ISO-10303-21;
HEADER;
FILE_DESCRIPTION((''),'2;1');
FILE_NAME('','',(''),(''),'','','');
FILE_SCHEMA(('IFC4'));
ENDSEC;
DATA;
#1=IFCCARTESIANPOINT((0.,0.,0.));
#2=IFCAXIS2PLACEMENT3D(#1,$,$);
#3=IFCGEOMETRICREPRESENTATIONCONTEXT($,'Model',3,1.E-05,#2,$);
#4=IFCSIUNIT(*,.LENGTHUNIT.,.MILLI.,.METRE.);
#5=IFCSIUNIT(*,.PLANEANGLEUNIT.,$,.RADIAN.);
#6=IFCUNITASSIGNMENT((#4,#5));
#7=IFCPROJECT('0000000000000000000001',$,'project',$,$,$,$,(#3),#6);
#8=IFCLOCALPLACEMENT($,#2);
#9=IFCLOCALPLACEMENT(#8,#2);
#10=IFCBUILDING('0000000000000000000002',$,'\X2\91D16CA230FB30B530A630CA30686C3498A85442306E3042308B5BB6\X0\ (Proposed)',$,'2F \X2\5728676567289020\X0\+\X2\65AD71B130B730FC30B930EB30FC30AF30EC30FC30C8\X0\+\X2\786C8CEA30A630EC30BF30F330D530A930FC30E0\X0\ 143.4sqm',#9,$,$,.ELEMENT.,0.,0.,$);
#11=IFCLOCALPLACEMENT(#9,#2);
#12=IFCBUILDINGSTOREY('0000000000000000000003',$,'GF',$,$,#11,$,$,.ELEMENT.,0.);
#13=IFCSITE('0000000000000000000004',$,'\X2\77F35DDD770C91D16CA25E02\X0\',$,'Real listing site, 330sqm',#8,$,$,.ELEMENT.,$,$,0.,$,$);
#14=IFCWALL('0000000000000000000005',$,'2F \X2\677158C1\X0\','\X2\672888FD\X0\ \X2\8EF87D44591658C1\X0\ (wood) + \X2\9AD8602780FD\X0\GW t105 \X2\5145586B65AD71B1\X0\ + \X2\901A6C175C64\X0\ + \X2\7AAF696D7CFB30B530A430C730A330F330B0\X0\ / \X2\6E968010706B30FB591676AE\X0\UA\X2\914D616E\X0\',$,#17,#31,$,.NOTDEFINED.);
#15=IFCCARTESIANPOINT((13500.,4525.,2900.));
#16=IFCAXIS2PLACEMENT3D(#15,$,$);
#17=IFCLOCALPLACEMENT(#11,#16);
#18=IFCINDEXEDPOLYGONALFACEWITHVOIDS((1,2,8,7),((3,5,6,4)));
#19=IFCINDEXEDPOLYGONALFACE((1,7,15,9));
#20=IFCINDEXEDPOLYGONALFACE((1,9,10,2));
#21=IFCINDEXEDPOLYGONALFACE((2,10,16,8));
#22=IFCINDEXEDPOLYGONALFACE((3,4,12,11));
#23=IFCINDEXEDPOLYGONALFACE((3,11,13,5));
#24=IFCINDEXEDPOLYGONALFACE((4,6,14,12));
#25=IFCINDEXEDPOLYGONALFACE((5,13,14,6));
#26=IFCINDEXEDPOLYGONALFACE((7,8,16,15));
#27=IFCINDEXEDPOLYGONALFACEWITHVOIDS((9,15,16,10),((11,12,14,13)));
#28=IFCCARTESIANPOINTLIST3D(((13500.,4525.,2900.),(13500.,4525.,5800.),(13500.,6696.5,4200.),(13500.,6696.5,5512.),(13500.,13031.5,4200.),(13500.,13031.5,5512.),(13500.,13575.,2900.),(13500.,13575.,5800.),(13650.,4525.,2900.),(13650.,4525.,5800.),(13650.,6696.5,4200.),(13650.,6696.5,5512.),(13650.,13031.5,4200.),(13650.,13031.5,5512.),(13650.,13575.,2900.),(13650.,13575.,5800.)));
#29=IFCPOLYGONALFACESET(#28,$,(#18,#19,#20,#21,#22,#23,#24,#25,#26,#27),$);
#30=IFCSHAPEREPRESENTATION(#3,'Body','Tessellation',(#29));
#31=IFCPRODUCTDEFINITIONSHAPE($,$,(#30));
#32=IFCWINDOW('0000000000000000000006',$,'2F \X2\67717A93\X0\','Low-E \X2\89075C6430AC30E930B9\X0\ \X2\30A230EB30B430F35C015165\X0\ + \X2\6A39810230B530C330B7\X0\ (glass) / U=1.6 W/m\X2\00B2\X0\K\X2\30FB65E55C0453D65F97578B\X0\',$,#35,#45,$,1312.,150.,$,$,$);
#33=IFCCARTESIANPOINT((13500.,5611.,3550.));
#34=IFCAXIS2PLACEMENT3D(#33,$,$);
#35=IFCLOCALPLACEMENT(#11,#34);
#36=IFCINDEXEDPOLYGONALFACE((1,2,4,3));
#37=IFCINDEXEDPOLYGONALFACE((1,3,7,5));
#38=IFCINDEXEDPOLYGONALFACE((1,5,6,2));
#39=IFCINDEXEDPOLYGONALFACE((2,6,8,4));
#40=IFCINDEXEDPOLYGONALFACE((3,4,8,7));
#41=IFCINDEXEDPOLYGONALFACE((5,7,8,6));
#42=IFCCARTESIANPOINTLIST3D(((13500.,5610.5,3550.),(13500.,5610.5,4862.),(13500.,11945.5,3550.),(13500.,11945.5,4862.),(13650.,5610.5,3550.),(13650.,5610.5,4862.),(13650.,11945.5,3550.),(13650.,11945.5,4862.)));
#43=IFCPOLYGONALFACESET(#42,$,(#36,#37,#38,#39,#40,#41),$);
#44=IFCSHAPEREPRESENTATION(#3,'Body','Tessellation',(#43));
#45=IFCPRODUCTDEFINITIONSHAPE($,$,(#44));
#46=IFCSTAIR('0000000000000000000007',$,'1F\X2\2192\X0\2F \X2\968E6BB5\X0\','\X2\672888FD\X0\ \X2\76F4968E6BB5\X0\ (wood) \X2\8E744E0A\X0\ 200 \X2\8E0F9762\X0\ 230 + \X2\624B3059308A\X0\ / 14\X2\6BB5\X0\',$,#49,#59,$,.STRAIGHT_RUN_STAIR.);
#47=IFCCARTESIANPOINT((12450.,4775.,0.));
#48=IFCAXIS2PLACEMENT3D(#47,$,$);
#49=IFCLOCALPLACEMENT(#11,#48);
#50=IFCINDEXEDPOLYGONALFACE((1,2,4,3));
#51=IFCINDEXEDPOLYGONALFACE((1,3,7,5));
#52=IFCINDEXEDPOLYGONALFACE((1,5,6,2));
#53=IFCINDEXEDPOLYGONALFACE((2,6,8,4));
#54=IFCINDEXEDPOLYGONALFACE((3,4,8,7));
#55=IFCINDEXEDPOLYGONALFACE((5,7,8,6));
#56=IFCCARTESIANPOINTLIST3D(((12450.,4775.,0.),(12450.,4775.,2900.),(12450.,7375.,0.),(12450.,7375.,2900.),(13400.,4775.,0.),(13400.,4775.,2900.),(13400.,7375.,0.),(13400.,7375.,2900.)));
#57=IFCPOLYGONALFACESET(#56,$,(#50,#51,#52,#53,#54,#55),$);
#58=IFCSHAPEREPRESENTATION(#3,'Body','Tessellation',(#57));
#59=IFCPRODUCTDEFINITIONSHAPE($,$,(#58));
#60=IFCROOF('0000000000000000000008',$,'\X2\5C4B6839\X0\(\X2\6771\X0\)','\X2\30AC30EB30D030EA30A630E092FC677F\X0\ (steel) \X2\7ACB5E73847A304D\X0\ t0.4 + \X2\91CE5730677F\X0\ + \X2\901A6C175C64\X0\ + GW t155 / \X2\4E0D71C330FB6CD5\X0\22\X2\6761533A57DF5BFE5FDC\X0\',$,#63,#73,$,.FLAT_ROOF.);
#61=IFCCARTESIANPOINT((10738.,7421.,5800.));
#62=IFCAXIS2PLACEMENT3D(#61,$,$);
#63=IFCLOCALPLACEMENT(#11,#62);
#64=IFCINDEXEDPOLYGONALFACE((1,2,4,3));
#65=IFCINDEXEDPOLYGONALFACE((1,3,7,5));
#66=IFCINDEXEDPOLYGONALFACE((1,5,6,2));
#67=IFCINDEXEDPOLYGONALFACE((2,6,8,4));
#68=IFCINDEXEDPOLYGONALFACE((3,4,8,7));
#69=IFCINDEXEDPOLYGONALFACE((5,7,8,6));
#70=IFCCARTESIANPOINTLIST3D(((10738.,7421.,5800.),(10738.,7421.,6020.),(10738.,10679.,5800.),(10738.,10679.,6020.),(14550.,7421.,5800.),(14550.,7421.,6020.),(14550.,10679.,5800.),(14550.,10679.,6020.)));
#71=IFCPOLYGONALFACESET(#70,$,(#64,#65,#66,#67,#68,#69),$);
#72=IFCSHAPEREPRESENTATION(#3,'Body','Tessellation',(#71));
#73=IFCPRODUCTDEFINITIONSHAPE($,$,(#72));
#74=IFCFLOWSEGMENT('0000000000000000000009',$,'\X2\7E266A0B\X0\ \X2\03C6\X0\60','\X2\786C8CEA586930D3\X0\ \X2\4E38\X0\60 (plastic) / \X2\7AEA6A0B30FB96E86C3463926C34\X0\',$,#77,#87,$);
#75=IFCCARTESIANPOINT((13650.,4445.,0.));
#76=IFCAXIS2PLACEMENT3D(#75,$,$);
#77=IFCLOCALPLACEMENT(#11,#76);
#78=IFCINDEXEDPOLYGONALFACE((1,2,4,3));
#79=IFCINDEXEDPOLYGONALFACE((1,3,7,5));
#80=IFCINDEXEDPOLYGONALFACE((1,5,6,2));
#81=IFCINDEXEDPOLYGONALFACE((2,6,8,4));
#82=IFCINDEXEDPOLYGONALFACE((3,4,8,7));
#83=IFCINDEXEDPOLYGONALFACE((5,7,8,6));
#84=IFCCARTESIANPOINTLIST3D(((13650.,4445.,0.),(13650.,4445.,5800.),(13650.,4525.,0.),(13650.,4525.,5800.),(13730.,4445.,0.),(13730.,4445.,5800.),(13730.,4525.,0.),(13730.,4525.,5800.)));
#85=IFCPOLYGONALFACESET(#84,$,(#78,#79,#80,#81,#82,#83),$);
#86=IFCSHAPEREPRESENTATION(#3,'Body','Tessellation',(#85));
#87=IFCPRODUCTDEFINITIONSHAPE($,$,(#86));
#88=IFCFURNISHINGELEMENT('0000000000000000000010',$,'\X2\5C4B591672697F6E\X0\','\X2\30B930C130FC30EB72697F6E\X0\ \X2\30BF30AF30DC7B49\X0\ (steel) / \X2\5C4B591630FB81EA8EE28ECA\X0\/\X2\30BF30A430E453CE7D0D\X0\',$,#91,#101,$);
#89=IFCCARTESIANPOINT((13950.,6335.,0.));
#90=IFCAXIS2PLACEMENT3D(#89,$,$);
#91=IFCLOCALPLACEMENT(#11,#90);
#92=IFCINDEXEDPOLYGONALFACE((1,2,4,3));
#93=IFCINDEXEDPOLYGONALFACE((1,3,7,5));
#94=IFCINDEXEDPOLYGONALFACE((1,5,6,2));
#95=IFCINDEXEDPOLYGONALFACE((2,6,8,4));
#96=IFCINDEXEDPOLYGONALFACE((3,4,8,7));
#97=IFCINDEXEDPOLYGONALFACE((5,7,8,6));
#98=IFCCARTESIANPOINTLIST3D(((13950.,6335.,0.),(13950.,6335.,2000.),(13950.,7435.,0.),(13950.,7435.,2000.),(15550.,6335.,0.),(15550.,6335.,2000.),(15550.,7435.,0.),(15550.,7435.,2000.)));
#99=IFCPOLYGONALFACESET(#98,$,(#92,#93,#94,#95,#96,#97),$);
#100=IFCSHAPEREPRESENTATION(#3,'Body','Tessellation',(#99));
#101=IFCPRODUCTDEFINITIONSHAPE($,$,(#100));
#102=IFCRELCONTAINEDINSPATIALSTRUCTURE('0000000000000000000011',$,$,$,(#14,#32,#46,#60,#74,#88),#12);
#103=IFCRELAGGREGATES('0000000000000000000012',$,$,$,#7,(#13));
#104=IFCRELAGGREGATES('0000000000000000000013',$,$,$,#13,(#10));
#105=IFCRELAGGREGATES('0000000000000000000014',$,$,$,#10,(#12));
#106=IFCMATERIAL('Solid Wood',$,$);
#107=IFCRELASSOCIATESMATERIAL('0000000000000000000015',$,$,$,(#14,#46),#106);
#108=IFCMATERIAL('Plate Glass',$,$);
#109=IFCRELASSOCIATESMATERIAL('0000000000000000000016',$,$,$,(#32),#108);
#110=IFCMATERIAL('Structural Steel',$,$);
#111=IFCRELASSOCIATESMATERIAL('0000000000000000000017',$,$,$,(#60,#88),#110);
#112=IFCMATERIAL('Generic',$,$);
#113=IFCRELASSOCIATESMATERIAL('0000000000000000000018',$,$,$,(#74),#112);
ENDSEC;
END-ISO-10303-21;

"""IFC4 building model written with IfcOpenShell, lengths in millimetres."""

from ifc_helpers import new_model, si_unit, frame, frame_2d, origin, place, context, project, spatial, rectangle, extrude, material, element, fill, save


model = new_model("IFC4")

# Units and contexts
model_context = context("Model", 3, precision=1e-05, world=origin())
ifc_project = project(units=[si_unit("LENGTHUNIT", "METRE", prefix="MILLI"), si_unit("PLANEANGLEUNIT", "RADIAN")], contexts=[model_context])

# Site, building, storey
site_placement = place(None, origin())
site = spatial("IfcSite", under=ifc_project, at=site_placement, Name="石川県金沢市", ObjectType="Real listing site, 330sqm", CompositionType="ELEMENT", RefElevation=0.0)
building_placement = place(site_placement, origin())
building = spatial("IfcBuilding", under=site, at=building_placement, Name="金沢・サウナと水風呂のある家 (Proposed)", ObjectType="2F 在来木造+断熱シースルークレート+硬質ウレタンフォーム 143.4sqm", CompositionType="ELEMENT", ElevationOfRefHeight=0.0, ElevationOfTerrain=0.0)
storey_placement = place(building_placement, origin())
storey = spatial("IfcBuildingStorey", under=building, at=storey_placement, Name="GF", CompositionType="ELEMENT", Elevation=0.0)

# Shared definitions
ifc_material_1 = material(Name="Solid Wood")

# Wall, opening, window
ifc_material_2 = material(Name="Plate Glass")
wall_1_placement = place(storey_placement, frame((13500.0, 4525.0, 2900.0)))
wall_1 = element("IfcWall", 1, at=wall_1_placement, inside=storey, material=ifc_material_1, Name="2F 東壁", Description="木製 軸組外壁 (wood) + 高性能GW t105 充填断熱 + 通気層 + 窯業系サイディング / 準耐火・外皮UA配慮", PredefinedType="NOTDEFINED", context=model_context, shape_type="SweptSolid", body=[
    extrude(rectangle(XDim=150.0, YDim=9050.0, at=frame_2d((75.0, 4525.0))), frame((13500.0, 4525.0, 2900.0)), (0.0, 0.0, 1.0), 2900.0),
])
opening_1_placement = place(storey_placement, frame((13500.0, 5611.0, 3550.0)))
opening_1 = element("IfcOpeningElement", 2, at=opening_1_placement, cuts=wall_1, PredefinedType="NOTDEFINED", context=model_context, shape_type="SweptSolid", body=[
    extrude(rectangle(XDim=150.0, YDim=6335.0, at=frame_2d((75.0, 3167.0))), frame((13500.0, 5611.0, 3550.0)), (0.0, 0.0, 1.0), 1312.0),
])
window_1_placement = place(storey_placement, frame((13500.0, 5611.0, 3550.0)))
window_1 = element("IfcWindow", 3, at=window_1_placement, inside=storey, material=ifc_material_2, Name="2F 東窓", Description="Low-E 複層ガラス アルゴン封入 + 樹脂サッシ (glass) / U=1.6 W/m²K・日射取得型", OverallHeight=1312.0, OverallWidth=150.0, context=model_context, shape_type="SweptSolid", body=[
    extrude(rectangle(XDim=150.0, YDim=6335.0, at=frame_2d((75.0, 3167.0))), frame((13500.0, 5611.0, 3550.0)), (0.0, 0.0, 1.0), 1312.0),
])
fill(opening_1, window_1)

# Stair
stair_placement = place(storey_placement, frame((12450.0, 4775.0, 0.0)))
element("IfcStair", 4, at=stair_placement, inside=storey, material=ifc_material_1, Name="1F→2F 階段", Description="木製 直階段 (wood) 蹴上 200 踏面 230 + 手すり / 14段", PredefinedType="STRAIGHT_RUN_STAIR", context=model_context, shape_type="SweptSolid", body=[
    extrude(rectangle(XDim=950.0, YDim=2600.0, at=frame_2d((475.0, 1300.0))), frame((12450.0, 4775.0, 0.0)), (0.0, 0.0, 1.0), 2900.0),
])

# Roof
ifc_material_3 = material(Name="Structural Steel")
for number, where, name in (
    (5, (10738.0, 7421.0, 5800.0), "屋根(東)"),
):
    element("IfcRoof", number, at=place(storey_placement, frame(where)), inside=storey, material=ifc_material_3, Name=name, Description="ガルバリウム鋼板 (steel) 立平葺き t0.4 + 野地板 + 通気層 + GW t155 / 不燃・法22条区域対応", PredefinedType="FLAT_ROOF", context=model_context, shape_type="SweptSolid", body=[
        extrude(rectangle(XDim=3812.0, YDim=3258.0, at=frame_2d((1906.0, 1629.0))), frame((10738.0, 7421.0, 5800.0)), (0.0, 0.0, 1.0), 220.0),
    ])

# Flow segment
ifc_material_4 = material(Name="Generic")
flow_segment_placement = place(storey_placement, frame((13650.0, 4445.0, 0.0)))
element("IfcFlowSegment", 6, at=flow_segment_placement, inside=storey, material=ifc_material_4, Name="縦樋 φ60", Description="硬質塩ビ 丸60 (plastic) / 竪樋・雨水排水", context=model_context, shape_type="SweptSolid", body=[
    extrude(rectangle(XDim=80.0, YDim=80.0, at=frame_2d((40.0, 40.0))), frame((13650.0, 4445.0, 0.0)), (0.0, 0.0, 1.0), 5800.0),
])

# Furnishing element
furnishing_placement = place(storey_placement, frame((13950.0, 6335.0, 0.0)))
element("IfcFurnishingElement", 7, at=furnishing_placement, inside=storey, material=ifc_material_3, Name="屋外物置", Description="スチール物置 タクボ等 (steel) / 屋外・自転車/タイヤ収納", context=model_context, shape_type="SweptSolid", body=[
    extrude(rectangle(XDim=1600.0, YDim=1100.0, at=frame_2d((800.0, 550.0))), frame((13950.0, 6335.0, 0.0)), (0.0, 0.0, 1.0), 2000.0),
])

save(model, "model.ifc")
